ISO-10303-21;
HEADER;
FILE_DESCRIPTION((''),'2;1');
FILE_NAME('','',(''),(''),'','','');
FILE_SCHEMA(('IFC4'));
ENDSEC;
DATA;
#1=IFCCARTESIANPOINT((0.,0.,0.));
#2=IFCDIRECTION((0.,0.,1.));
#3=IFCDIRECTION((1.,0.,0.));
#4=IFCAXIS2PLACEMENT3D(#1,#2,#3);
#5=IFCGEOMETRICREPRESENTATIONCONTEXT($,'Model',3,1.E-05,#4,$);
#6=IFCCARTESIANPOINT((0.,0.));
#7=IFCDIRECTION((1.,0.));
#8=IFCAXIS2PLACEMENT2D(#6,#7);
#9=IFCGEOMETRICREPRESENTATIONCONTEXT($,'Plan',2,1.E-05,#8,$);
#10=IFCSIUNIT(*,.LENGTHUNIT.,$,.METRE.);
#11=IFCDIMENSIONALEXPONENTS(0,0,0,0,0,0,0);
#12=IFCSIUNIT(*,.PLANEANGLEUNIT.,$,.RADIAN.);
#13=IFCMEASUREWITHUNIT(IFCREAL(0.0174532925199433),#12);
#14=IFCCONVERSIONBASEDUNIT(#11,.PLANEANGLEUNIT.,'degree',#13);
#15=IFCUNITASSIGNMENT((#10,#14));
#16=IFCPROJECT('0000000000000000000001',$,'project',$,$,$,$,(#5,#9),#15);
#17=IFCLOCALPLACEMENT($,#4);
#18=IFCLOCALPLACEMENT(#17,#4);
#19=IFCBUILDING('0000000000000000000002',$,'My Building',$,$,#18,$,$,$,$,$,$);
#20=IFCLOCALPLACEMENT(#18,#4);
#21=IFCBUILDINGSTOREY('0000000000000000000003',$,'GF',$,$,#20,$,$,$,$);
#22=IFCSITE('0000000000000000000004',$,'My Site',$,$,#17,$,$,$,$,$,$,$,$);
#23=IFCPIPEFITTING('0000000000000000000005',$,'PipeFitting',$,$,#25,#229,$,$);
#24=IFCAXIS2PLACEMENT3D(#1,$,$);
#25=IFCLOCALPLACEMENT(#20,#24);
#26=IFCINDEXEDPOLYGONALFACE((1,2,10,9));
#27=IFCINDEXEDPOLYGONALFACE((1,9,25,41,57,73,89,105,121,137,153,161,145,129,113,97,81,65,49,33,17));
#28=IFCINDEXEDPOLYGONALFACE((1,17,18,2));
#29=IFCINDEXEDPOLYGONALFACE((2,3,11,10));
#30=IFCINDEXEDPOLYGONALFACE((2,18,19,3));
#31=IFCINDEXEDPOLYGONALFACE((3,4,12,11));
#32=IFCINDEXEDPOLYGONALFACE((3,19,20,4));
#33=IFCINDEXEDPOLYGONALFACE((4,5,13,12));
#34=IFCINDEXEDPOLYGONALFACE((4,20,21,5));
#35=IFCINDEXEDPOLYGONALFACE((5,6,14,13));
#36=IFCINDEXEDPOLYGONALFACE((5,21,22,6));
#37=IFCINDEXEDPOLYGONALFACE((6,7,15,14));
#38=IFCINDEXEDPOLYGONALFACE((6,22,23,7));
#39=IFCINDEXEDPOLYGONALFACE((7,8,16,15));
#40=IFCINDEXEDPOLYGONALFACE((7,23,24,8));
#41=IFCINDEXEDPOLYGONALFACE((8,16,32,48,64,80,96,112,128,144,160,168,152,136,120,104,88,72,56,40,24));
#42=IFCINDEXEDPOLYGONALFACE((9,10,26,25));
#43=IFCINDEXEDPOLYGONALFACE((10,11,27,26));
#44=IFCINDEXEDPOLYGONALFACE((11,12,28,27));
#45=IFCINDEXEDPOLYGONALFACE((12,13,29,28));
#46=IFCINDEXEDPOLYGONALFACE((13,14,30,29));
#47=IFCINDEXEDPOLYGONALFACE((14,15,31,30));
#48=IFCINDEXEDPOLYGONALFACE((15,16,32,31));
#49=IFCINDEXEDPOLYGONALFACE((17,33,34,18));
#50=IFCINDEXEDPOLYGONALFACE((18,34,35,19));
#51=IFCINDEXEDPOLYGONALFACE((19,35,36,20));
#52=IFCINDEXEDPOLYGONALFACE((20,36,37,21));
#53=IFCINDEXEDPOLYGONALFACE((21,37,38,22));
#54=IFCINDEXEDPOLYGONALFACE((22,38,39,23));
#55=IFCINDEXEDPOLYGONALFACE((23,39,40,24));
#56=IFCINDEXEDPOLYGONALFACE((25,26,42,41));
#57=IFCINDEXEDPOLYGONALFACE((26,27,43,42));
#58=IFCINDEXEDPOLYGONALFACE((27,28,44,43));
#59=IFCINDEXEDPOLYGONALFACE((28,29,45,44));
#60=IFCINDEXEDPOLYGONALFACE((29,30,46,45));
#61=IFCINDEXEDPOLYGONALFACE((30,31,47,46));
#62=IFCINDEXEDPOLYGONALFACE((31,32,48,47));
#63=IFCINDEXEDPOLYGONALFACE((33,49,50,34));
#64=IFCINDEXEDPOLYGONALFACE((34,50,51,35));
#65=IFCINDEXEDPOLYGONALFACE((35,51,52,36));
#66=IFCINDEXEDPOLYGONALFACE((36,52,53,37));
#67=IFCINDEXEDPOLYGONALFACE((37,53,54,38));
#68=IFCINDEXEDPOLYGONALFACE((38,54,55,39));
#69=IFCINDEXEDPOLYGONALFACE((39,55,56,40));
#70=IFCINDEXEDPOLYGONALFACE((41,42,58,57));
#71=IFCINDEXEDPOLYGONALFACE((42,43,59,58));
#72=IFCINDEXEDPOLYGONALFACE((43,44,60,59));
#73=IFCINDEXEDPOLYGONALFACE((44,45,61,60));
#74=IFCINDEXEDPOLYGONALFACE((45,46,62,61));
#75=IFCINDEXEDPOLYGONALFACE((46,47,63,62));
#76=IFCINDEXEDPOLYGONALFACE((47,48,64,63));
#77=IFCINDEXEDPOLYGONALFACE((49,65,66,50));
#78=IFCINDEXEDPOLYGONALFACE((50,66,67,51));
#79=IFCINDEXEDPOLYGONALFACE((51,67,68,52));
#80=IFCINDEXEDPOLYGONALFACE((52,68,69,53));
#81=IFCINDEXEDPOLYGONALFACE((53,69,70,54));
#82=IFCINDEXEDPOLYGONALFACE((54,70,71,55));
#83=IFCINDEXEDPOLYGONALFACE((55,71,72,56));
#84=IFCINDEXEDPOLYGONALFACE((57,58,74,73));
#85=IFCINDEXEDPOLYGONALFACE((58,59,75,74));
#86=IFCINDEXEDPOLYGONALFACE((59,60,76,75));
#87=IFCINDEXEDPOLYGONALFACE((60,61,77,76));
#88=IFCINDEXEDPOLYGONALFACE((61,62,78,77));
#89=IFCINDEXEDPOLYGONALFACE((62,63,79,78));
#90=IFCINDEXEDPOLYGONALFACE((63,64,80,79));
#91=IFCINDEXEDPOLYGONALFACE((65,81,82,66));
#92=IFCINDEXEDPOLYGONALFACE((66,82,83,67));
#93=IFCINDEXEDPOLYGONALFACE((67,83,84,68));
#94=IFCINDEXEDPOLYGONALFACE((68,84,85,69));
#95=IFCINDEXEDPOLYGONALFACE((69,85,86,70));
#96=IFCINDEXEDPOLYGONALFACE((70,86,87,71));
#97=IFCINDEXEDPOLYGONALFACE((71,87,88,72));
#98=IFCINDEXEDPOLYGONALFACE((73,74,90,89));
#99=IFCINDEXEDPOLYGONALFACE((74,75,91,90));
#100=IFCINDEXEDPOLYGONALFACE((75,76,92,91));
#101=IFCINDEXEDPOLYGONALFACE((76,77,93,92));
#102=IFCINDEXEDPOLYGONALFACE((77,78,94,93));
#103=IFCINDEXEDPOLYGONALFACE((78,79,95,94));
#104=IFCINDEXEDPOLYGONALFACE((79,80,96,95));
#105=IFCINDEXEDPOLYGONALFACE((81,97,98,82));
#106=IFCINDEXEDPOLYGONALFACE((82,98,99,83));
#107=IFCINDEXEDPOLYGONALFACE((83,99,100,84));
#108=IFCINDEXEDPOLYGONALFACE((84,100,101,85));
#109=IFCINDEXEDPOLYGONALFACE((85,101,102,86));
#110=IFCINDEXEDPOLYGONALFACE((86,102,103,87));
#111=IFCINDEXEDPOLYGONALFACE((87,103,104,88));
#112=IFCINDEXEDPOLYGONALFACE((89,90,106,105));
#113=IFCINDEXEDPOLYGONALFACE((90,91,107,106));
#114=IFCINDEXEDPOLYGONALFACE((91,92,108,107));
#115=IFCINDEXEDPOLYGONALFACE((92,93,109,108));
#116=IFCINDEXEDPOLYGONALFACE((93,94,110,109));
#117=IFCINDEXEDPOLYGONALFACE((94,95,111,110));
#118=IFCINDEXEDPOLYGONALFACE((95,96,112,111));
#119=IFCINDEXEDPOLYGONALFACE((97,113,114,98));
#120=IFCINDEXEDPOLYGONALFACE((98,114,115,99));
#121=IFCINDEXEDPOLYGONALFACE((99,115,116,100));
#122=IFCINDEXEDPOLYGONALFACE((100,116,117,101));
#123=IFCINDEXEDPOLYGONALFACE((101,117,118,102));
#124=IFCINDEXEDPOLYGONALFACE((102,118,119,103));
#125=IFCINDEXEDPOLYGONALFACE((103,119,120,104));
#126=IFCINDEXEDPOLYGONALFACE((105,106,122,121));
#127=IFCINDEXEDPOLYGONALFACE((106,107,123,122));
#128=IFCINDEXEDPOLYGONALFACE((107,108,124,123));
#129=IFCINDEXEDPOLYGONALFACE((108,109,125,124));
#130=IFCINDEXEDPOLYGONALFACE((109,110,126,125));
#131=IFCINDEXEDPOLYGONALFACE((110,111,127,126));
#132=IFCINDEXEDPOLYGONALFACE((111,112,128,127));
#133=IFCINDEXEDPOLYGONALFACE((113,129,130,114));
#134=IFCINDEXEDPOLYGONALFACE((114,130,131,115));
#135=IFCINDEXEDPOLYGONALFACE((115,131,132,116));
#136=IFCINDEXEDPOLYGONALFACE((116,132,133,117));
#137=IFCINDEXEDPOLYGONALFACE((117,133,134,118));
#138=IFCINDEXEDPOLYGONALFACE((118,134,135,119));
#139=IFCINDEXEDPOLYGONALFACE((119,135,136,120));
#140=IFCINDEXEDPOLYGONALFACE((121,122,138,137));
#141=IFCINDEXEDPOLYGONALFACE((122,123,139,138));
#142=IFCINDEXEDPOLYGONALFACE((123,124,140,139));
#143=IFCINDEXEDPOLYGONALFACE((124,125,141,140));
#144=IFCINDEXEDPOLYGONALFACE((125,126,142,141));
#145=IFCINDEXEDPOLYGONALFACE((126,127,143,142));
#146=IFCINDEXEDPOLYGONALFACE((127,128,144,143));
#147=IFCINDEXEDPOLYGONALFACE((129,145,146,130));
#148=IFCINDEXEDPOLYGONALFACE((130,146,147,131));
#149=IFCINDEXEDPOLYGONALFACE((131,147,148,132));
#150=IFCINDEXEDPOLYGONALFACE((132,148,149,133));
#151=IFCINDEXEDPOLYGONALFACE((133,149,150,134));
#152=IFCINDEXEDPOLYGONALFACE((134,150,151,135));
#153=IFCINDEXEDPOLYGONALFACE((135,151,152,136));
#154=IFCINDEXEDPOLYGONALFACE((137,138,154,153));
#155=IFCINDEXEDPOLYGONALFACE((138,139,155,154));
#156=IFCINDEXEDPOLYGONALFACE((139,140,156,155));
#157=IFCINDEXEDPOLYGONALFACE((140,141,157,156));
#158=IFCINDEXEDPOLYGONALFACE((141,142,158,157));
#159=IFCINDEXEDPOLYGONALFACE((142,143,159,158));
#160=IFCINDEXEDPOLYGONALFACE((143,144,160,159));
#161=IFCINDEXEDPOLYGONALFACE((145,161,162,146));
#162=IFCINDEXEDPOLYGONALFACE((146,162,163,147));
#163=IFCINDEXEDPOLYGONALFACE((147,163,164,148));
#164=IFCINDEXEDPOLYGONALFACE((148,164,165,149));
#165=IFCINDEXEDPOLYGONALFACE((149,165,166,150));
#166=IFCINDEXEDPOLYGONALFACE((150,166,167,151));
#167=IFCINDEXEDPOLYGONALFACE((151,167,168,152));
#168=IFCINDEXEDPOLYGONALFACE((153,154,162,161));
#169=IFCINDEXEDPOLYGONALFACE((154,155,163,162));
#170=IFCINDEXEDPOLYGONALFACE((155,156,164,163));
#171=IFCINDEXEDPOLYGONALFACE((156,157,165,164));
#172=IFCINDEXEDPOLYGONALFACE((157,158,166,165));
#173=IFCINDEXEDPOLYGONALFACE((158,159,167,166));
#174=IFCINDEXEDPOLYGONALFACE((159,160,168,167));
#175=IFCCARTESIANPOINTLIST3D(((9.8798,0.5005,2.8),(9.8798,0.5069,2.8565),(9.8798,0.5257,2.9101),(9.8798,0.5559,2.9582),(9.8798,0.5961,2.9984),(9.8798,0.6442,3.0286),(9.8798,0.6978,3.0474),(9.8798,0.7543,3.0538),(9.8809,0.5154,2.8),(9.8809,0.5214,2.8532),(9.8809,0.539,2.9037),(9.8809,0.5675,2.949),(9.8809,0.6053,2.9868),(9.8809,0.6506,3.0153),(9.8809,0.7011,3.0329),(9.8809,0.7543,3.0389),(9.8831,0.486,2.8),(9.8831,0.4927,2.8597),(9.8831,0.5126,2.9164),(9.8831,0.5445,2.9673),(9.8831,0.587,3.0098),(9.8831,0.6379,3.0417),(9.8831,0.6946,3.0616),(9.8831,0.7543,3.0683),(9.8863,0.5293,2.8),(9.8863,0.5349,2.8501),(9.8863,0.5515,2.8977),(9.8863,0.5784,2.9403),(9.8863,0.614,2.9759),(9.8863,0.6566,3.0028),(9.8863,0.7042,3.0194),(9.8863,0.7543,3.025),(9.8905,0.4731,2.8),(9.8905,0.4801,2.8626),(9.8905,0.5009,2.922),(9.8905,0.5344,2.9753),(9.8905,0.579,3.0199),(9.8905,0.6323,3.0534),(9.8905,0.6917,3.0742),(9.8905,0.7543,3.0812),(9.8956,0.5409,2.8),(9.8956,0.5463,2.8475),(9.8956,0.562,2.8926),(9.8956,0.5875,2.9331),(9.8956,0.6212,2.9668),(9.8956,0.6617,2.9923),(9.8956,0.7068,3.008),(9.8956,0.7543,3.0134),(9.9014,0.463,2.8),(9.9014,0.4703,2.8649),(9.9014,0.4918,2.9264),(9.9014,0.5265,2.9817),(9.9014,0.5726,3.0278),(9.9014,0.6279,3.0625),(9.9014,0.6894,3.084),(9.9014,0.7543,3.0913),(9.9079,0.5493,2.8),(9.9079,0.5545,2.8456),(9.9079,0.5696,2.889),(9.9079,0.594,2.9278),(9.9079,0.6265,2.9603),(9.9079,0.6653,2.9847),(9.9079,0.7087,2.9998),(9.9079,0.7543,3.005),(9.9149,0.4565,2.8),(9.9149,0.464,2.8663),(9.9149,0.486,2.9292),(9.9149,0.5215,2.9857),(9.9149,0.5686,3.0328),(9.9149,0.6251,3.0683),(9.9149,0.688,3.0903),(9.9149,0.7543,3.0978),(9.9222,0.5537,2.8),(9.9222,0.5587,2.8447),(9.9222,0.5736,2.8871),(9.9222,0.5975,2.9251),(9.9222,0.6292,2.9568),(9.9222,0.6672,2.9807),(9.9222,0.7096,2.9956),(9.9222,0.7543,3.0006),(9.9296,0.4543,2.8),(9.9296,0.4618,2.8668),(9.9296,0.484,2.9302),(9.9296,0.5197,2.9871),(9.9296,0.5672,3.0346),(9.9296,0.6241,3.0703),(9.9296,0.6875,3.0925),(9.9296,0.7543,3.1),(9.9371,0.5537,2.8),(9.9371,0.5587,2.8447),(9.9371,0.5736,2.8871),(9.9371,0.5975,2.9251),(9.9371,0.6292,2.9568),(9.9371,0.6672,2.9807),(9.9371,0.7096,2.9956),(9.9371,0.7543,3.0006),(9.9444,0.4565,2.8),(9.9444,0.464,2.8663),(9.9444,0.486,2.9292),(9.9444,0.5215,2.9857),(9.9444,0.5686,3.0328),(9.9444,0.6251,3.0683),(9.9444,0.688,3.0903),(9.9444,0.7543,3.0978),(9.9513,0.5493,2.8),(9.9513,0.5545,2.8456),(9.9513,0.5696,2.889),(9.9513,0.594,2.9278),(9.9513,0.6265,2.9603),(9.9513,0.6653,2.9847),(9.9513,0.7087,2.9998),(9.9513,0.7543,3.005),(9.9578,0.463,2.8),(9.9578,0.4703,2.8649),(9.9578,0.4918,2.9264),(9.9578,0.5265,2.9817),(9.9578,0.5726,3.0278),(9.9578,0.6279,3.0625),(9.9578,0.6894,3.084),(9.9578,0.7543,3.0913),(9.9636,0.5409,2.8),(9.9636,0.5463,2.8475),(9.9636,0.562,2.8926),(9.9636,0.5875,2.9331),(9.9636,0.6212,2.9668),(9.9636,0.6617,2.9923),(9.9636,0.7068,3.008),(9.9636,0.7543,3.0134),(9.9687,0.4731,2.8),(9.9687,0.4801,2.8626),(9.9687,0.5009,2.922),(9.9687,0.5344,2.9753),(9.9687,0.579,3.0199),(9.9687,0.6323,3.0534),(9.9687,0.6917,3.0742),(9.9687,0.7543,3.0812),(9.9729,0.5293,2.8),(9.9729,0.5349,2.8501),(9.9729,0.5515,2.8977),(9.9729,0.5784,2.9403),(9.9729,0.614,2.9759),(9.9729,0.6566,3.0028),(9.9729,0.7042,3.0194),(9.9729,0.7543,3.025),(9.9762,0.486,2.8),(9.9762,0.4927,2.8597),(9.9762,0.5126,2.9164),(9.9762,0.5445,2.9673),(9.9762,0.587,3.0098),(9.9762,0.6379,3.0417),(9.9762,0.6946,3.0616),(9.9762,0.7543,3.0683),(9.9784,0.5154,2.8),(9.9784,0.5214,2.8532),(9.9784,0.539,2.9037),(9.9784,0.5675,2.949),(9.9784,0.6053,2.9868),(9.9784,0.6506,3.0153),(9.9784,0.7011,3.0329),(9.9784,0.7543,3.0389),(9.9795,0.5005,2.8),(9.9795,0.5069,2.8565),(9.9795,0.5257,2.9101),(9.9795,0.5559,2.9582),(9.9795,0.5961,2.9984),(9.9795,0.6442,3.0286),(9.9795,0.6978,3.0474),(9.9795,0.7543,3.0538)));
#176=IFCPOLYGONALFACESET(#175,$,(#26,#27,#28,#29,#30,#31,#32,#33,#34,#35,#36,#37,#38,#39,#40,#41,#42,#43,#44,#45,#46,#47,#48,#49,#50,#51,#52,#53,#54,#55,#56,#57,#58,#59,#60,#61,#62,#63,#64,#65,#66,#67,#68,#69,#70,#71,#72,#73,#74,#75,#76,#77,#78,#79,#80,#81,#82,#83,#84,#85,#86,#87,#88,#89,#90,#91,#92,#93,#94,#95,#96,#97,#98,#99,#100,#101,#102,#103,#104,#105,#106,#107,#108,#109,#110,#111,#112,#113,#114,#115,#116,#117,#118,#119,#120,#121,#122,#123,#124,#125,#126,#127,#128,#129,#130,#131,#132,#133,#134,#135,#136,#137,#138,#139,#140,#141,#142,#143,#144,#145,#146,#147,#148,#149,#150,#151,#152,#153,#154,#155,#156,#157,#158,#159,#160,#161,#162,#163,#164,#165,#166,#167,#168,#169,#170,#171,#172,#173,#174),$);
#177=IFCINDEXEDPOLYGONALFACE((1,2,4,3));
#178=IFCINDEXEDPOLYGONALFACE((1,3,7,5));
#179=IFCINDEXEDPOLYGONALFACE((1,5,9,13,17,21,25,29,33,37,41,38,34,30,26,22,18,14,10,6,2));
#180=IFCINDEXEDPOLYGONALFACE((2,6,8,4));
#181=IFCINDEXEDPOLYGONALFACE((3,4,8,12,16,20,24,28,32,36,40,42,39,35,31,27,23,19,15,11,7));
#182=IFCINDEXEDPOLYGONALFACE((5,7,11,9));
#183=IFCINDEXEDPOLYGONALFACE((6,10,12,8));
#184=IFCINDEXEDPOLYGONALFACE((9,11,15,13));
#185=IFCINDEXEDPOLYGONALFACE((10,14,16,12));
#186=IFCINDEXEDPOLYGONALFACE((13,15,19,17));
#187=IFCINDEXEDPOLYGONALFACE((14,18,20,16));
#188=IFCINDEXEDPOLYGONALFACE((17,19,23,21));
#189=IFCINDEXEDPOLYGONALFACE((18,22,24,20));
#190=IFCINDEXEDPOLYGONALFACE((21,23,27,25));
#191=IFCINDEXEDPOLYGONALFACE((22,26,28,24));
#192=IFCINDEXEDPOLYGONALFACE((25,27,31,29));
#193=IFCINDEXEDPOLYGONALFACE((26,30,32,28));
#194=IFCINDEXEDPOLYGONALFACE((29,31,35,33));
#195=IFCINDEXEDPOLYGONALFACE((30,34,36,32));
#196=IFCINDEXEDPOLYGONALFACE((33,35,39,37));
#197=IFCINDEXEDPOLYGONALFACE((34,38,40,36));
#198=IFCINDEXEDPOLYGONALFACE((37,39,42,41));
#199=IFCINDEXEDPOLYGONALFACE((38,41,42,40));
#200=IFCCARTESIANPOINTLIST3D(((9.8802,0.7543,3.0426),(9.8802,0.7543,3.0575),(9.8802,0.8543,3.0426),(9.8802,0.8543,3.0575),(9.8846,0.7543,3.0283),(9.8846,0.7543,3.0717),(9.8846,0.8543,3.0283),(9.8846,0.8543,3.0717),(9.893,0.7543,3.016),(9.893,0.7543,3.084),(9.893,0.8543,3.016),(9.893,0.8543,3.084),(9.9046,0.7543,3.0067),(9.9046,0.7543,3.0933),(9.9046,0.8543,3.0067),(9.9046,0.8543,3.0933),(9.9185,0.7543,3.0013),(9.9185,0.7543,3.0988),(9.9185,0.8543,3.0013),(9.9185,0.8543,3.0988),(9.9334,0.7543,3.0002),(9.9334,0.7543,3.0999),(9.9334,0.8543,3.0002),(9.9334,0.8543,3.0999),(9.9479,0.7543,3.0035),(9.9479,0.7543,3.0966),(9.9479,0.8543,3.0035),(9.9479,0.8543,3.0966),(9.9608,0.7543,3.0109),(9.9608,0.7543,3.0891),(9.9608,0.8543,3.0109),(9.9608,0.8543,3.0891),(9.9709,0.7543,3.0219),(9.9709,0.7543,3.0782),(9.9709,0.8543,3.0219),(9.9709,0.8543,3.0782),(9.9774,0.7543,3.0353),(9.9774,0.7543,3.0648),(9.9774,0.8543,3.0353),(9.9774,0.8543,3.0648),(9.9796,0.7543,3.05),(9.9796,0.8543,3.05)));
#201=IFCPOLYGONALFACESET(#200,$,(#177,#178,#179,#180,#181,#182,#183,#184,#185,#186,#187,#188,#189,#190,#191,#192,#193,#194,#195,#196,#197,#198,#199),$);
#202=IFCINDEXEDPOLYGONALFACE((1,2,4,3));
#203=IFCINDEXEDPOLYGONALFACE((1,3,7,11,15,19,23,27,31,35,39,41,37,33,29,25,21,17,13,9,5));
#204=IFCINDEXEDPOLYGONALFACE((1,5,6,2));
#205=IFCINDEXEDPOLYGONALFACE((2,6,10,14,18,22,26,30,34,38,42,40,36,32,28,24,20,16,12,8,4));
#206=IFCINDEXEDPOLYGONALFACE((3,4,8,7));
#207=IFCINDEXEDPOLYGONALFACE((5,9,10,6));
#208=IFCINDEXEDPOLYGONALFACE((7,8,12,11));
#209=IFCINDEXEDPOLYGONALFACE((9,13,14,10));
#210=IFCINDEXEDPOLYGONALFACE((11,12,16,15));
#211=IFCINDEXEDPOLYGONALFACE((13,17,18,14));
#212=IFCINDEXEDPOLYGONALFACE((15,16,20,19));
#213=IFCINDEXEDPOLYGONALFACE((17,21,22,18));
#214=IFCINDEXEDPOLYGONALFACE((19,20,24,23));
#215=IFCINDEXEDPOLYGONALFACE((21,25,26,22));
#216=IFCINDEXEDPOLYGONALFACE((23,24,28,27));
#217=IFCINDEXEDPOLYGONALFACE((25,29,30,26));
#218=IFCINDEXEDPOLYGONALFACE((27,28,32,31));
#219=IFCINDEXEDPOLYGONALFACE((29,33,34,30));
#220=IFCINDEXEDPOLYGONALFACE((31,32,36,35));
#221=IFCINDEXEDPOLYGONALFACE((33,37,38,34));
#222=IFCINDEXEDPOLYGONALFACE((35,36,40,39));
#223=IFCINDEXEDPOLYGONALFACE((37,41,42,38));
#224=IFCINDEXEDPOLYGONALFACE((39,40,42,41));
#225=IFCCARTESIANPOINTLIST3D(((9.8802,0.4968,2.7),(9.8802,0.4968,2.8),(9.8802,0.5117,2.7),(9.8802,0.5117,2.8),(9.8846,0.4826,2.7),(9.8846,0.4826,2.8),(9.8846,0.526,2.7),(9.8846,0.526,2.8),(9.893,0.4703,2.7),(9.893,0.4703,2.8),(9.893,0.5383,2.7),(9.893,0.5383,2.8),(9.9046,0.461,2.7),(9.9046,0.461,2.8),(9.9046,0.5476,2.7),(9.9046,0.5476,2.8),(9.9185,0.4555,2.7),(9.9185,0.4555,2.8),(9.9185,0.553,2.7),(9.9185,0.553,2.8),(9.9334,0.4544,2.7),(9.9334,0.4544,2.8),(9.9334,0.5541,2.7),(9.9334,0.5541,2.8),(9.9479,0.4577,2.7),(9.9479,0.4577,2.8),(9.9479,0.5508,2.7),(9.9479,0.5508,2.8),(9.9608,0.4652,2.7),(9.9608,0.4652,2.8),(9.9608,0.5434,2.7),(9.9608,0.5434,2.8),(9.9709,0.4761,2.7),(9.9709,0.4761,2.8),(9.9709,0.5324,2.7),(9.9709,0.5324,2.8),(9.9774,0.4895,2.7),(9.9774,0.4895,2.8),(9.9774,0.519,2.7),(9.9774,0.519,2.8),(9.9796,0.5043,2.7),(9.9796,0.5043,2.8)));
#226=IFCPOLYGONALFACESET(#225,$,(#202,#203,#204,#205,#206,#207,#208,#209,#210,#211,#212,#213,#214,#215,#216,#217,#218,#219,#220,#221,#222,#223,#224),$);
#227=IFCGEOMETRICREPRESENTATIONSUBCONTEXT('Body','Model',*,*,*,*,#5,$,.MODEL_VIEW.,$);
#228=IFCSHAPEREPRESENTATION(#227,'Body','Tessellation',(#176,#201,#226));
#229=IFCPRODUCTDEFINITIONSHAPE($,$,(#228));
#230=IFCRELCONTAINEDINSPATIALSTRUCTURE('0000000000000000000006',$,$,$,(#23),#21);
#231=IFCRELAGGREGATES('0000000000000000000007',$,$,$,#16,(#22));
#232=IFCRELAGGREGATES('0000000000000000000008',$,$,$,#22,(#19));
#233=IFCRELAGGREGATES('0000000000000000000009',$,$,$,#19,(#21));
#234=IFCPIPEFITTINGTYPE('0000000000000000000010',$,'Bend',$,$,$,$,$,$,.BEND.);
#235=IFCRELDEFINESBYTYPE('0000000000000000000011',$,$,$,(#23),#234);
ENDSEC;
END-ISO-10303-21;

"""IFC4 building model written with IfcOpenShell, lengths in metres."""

from ifc_helpers import new_model, entity, si_unit, converted_unit, frame, origin_with_axes, origin_2d_with_axis, place, context, subcontext, project, spatial, circle, extrude, source, transform, mapped, type_object, type_shapes, element, save


model = new_model("IFC4")

# Units and contexts
model_context = context("Model", 3, precision=1e-05, world=origin_with_axes())
plan_context = context("Plan", 2, precision=1e-05, world=origin_2d_with_axis())
body_context_1 = subcontext(model_context, "Body", "Model", "MODEL_VIEW")
ifc_project = project(units=[si_unit("LENGTHUNIT", "METRE"), converted_unit("PLANEANGLEUNIT", "degree", entity("IfcReal", 0.0174532925199433), si_unit("PLANEANGLEUNIT", "RADIAN"), dimensions=[0, 0, 0, 0, 0, 0, 0])], contexts=[model_context, plan_context])

# Site, building, storey
site_placement = place(None, origin_with_axes())
site = spatial("IfcSite", under=ifc_project, at=site_placement, Name="My Site")
building_placement = place(site_placement, origin_with_axes())
building = spatial("IfcBuilding", under=site, at=building_placement, Name="My Building")
storey_placement = place(building_placement, origin_with_axes())
storey = spatial("IfcBuildingStorey", under=building, at=storey_placement, Name="GF")

# Pipe fitting
pipe_fitting_type = type_object("IfcPipeFittingType", Name="Bend", PredefinedType="BEND")
shared_shape_1 = source(origin_with_axes(), body_context_1, "Body", "SolidModel", [
    entity("IfcSweptDiskSolid", entity("IfcIndexedPolyCurve", entity("IfcCartesianPointList3D", [[0.0, 0.0, 0.1], [0.0, -0.0732, 0.2768], [0.0, -0.25, 0.35]]), [entity("IfcArcIndex", [1, 2, 3])]), 0.05),
    extrude(circle(Radius=0.05), origin_with_axes(), (0.0, 0.0, 1.0), 0.1),
    extrude(circle(Radius=0.05), frame((0.0, -0.25, 0.35), z_axis=(0.0, -1.0, 0.0), x_axis=(1.0, 0.0, 0.0)), (0.0, 0.0, 1.0), 0.1),
])
type_shapes(pipe_fitting_type, [shared_shape_1])
for number, where, z_axis, x_axis, name in (
    (1, (9.9296, 0.8543, 3.05), (0.0, -1.0, 0.0), (1.0, 0.0, 0.0), "PipeFitting"),
):
    element("IfcPipeFitting", number, at=place(storey_placement, frame(where, z_axis=z_axis, x_axis=x_axis)), inside=storey, type_object=pipe_fitting_type, Name=name, context=body_context_1, shape_type="MappedRepresentation", body=[
        mapped(shared_shape_1, transform((0.0, 0.0, 0.0), x_axis=(1.0, 0.0, 0.0), y_axis=(0.0, 1.0, 0.0), z_axis=(0.0, 0.0, 1.0), scale=1.0)),
    ])

save(model, "model.ifc")
